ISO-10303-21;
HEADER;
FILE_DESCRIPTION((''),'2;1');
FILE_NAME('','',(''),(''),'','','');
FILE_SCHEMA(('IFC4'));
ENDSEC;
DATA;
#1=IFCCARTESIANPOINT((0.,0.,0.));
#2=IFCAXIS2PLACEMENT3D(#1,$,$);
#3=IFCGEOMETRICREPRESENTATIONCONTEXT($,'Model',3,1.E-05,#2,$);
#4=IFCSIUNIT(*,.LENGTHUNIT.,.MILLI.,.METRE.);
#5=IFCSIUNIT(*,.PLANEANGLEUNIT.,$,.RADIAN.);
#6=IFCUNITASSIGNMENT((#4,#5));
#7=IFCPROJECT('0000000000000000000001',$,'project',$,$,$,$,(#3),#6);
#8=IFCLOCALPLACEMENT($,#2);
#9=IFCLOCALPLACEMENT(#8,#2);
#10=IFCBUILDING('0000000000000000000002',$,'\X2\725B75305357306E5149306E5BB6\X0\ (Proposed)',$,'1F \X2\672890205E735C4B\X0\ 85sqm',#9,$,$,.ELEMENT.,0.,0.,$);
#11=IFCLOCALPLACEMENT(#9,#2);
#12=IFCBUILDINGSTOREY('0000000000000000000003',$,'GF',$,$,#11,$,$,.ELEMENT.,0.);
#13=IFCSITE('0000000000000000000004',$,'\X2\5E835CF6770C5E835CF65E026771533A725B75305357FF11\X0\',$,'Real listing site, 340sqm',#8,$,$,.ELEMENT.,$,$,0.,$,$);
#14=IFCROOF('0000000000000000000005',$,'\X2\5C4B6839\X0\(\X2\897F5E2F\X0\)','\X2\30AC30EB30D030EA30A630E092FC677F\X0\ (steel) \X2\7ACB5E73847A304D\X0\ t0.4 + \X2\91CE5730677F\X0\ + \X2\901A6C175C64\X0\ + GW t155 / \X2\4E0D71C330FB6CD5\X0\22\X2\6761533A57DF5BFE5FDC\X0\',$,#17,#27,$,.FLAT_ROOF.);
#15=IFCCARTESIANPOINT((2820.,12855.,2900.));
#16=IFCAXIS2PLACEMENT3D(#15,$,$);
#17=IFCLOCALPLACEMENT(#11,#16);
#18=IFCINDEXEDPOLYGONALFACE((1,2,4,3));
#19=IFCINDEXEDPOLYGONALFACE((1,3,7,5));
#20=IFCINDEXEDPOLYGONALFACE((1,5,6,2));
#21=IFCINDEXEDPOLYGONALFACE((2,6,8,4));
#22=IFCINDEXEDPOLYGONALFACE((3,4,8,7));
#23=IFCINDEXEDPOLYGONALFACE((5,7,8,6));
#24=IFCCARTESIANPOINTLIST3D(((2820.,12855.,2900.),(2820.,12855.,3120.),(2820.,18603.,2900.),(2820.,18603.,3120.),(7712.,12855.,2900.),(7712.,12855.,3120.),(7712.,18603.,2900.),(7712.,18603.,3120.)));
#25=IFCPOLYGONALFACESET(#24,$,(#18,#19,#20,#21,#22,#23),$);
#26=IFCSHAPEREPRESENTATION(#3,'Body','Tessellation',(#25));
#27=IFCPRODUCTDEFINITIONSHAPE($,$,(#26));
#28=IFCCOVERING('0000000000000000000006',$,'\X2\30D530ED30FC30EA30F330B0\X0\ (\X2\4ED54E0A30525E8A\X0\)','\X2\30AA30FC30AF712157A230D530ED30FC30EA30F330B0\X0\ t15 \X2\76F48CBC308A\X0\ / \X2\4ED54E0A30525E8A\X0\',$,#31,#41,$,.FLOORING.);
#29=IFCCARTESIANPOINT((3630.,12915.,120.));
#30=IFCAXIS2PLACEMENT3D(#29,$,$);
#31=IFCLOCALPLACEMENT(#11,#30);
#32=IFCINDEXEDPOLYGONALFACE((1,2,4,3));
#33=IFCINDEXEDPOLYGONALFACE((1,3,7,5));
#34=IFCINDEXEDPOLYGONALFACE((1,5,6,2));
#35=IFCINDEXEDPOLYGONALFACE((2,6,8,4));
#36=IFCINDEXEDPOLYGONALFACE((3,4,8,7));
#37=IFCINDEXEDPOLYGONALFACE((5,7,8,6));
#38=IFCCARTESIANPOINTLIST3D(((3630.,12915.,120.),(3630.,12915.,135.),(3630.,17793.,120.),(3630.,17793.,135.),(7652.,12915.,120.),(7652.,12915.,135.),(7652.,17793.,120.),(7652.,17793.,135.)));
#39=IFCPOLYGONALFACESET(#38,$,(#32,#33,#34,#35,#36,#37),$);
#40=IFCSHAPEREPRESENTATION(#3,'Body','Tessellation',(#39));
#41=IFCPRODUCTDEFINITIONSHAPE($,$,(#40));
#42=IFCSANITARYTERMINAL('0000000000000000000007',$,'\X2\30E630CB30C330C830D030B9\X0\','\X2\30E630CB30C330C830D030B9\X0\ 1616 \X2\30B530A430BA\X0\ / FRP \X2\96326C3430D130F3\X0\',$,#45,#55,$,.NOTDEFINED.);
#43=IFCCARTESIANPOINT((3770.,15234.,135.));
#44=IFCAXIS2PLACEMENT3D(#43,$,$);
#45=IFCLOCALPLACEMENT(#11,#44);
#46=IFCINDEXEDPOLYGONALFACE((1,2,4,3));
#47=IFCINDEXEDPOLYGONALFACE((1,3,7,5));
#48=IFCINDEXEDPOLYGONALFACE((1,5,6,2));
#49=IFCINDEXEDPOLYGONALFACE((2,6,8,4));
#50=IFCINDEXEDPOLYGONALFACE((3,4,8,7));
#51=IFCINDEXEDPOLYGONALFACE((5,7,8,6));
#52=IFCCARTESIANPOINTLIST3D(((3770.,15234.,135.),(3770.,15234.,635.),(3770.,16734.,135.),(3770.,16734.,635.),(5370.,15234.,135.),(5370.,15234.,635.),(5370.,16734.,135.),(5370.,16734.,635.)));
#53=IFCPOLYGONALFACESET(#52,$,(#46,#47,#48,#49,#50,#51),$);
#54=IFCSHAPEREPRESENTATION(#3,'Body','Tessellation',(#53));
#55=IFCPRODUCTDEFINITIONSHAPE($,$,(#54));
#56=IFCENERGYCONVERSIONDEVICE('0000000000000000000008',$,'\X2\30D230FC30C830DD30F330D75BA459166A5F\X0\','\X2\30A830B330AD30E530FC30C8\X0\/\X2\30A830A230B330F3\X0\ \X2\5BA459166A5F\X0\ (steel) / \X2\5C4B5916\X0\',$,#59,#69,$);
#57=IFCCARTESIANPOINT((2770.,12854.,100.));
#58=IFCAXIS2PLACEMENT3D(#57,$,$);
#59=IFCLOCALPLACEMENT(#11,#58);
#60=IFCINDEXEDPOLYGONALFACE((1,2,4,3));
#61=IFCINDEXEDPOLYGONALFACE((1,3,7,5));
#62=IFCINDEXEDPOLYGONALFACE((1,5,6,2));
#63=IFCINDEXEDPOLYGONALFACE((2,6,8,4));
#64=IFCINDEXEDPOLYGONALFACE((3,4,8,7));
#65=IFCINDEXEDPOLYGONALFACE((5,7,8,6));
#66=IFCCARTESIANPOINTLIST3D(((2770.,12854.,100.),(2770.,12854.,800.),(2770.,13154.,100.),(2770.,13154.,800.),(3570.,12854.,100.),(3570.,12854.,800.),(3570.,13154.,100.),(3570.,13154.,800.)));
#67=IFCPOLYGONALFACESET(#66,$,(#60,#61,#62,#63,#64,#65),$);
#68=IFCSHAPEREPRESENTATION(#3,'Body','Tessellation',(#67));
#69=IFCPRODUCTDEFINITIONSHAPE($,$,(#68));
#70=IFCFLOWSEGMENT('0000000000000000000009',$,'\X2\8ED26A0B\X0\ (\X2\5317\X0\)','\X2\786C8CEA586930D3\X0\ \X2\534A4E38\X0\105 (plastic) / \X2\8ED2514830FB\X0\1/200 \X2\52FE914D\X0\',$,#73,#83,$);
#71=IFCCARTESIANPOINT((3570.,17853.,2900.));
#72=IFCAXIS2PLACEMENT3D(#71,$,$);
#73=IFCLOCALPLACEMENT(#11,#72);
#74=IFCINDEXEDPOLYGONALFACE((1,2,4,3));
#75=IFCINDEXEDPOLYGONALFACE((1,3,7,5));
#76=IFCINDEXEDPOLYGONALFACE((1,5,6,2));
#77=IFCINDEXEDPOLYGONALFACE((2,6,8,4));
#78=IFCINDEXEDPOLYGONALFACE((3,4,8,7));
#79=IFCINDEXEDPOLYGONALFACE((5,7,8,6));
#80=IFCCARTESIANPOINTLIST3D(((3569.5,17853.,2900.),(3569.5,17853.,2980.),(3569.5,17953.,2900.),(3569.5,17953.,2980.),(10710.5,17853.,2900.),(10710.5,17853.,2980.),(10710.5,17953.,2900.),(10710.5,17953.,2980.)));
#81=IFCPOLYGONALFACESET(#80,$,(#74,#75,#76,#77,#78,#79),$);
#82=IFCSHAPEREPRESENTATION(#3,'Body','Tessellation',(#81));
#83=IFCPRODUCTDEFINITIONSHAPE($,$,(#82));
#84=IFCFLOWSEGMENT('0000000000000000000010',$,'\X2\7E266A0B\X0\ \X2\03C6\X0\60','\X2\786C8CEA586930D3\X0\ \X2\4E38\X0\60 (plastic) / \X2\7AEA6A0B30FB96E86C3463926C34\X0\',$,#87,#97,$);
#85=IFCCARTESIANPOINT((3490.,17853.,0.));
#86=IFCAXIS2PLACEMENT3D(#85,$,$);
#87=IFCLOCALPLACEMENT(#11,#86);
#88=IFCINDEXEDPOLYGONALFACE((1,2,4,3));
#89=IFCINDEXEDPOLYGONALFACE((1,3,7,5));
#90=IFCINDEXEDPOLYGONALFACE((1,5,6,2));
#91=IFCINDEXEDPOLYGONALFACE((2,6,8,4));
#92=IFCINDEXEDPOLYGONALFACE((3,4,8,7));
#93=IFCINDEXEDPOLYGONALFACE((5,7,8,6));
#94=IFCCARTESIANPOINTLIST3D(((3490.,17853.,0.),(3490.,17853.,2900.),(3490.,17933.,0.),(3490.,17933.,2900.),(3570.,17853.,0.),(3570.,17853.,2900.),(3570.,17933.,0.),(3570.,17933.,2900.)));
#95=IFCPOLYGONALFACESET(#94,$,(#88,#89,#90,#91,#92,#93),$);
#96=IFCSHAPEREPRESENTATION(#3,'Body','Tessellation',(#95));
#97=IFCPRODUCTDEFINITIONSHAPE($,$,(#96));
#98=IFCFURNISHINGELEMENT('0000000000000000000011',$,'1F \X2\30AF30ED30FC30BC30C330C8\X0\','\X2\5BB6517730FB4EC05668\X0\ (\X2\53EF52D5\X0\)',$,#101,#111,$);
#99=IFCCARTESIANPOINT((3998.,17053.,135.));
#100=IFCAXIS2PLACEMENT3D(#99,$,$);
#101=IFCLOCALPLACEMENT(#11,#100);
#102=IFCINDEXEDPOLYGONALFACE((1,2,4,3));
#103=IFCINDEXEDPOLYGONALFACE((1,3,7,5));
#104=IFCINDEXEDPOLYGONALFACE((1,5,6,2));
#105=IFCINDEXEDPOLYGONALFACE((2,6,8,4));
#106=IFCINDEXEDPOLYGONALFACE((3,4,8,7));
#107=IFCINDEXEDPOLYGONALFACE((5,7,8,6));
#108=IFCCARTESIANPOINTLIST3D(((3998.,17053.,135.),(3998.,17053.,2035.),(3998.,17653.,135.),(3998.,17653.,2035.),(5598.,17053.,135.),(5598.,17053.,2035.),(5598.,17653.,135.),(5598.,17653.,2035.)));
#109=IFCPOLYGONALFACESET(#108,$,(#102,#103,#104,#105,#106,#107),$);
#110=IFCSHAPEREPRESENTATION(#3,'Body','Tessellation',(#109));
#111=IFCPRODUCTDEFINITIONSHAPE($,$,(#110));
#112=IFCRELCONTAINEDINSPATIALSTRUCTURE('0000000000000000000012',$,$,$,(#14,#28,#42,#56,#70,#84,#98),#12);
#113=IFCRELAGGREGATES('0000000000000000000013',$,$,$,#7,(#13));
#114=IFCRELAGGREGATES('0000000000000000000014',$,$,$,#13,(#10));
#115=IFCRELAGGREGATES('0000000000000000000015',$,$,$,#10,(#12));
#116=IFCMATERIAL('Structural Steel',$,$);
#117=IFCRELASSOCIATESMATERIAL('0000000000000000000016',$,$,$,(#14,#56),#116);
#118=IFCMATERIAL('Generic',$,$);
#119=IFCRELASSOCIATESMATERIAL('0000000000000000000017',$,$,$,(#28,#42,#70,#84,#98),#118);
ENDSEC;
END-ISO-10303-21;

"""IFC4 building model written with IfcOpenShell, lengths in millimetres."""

from ifc_helpers import new_model, si_unit, frame, frame_2d, origin, place, context, project, spatial, rectangle, extrude, material, element, save


model = new_model("IFC4")

# Units and contexts
model_context = context("Model", 3, precision=1e-05, world=origin())
ifc_project = project(units=[si_unit("LENGTHUNIT", "METRE", prefix="MILLI"), si_unit("PLANEANGLEUNIT", "RADIAN")], contexts=[model_context])

# Site, building, storey
site_placement = place(None, origin())
site = spatial("IfcSite", under=ifc_project, at=site_placement, Name="広島県広島市東区牛田南１", ObjectType="Real listing site, 340sqm", CompositionType="ELEMENT", RefElevation=0.0)
building_placement = place(site_placement, origin())
building = spatial("IfcBuilding", under=site, at=building_placement, Name="牛田南の光の家 (Proposed)", ObjectType="1F 木造平屋 85sqm", CompositionType="ELEMENT", ElevationOfRefHeight=0.0, ElevationOfTerrain=0.0)
storey_placement = place(building_placement, origin())
storey = spatial("IfcBuildingStorey", under=building, at=storey_placement, Name="GF", CompositionType="ELEMENT", Elevation=0.0)

# Roof
ifc_material_1 = material(Name="Structural Steel")
roof_placement = place(storey_placement, frame((2820.0, 12855.0, 2900.0)))
element("IfcRoof", 1, at=roof_placement, inside=storey, material=ifc_material_1, Name="屋根(西帯)", Description="ガルバリウム鋼板 (steel) 立平葺き t0.4 + 野地板 + 通気層 + GW t155 / 不燃・法22条区域対応", PredefinedType="FLAT_ROOF", context=model_context, shape_type="SweptSolid", body=[
    extrude(rectangle(XDim=4892.0, YDim=5748.0, at=frame_2d((2446.0, 2874.0))), frame((2820.0, 12855.0, 2900.0)), (0.0, 0.0, 1.0), 220.0),
])

# Covering
ifc_material_2 = material(Name="Generic")
covering_placement = place(storey_placement, frame((3630.0, 12915.0, 120.0)))
element("IfcCovering", 2, at=covering_placement, inside=storey, material=ifc_material_2, Name="フローリング (仕上げ床)", Description="オーク無垢フローリング t15 直貼り / 仕上げ床", PredefinedType="FLOORING", context=model_context, shape_type="SweptSolid", body=[
    extrude(rectangle(XDim=4022.0, YDim=4878.0, at=frame_2d((2011.0, 2439.0))), frame((3630.0, 12915.0, 120.0)), (0.0, 0.0, 1.0), 15.0),
])

# Sanitary terminal
sanitary_terminal_placement = place(storey_placement, frame((3770.0, 15234.0, 135.0)))
element("IfcSanitaryTerminal", 3, at=sanitary_terminal_placement, inside=storey, material=ifc_material_2, Name="ユニットバス", Description="ユニットバス 1616 サイズ / FRP 防水パン", PredefinedType="NOTDEFINED", context=model_context, shape_type="SweptSolid", body=[
    extrude(rectangle(XDim=1600.0, YDim=1500.0, at=frame_2d((800.0, 750.0))), frame((3770.0, 15234.0, 135.0)), (0.0, 0.0, 1.0), 500.0),
])

# Energy conversion device
energy_conversion_device_placement = place(storey_placement, frame((2770.0, 12854.0, 100.0)))
element("IfcEnergyConversionDevice", 4, at=energy_conversion_device_placement, inside=storey, material=ifc_material_1, Name="ヒートポンプ室外機", Description="エコキュート/エアコン 室外機 (steel) / 屋外", context=model_context, shape_type="SweptSolid", body=[
    extrude(rectangle(XDim=800.0, YDim=300.0, at=frame_2d((400.0, 150.0))), frame((2770.0, 12854.0, 100.0)), (0.0, 0.0, 1.0), 700.0),
])

# Flow segments
flow_segment_1_placement = place(storey_placement, frame((3570.0, 17853.0, 2900.0)))
element("IfcFlowSegment", 5, at=flow_segment_1_placement, inside=storey, material=ifc_material_2, Name="軒樋 (北)", Description="硬質塩ビ 半丸105 (plastic) / 軒先・1/200 勾配", context=model_context, shape_type="SweptSolid", body=[
    extrude(rectangle(XDim=7141.0, YDim=100.0, at=frame_2d((3570.0, 50.0))), frame((3570.0, 17853.0, 2900.0)), (0.0, 0.0, 1.0), 80.0),
])
flow_segment_2_placement = place(storey_placement, frame((3490.0, 17853.0, 0.0)))
element("IfcFlowSegment", 6, at=flow_segment_2_placement, inside=storey, material=ifc_material_2, Name="縦樋 φ60", Description="硬質塩ビ 丸60 (plastic) / 竪樋・雨水排水", context=model_context, shape_type="SweptSolid", body=[
    extrude(rectangle(XDim=80.0, YDim=80.0, at=frame_2d((40.0, 40.0))), frame((3490.0, 17853.0, 0.0)), (0.0, 0.0, 1.0), 2900.0),
])

# Furnishing element
furnishing_placement = place(storey_placement, frame((3998.0, 17053.0, 135.0)))
element("IfcFurnishingElement", 7, at=furnishing_placement, inside=storey, material=ifc_material_2, Name="1F クローゼット", Description="家具・什器 (可動)", context=model_context, shape_type="SweptSolid", body=[
    extrude(rectangle(XDim=1600.0, YDim=600.0, at=frame_2d((800.0, 300.0))), frame((3998.0, 17053.0, 135.0)), (0.0, 0.0, 1.0), 1900.0),
])

save(model, "model.ifc")
